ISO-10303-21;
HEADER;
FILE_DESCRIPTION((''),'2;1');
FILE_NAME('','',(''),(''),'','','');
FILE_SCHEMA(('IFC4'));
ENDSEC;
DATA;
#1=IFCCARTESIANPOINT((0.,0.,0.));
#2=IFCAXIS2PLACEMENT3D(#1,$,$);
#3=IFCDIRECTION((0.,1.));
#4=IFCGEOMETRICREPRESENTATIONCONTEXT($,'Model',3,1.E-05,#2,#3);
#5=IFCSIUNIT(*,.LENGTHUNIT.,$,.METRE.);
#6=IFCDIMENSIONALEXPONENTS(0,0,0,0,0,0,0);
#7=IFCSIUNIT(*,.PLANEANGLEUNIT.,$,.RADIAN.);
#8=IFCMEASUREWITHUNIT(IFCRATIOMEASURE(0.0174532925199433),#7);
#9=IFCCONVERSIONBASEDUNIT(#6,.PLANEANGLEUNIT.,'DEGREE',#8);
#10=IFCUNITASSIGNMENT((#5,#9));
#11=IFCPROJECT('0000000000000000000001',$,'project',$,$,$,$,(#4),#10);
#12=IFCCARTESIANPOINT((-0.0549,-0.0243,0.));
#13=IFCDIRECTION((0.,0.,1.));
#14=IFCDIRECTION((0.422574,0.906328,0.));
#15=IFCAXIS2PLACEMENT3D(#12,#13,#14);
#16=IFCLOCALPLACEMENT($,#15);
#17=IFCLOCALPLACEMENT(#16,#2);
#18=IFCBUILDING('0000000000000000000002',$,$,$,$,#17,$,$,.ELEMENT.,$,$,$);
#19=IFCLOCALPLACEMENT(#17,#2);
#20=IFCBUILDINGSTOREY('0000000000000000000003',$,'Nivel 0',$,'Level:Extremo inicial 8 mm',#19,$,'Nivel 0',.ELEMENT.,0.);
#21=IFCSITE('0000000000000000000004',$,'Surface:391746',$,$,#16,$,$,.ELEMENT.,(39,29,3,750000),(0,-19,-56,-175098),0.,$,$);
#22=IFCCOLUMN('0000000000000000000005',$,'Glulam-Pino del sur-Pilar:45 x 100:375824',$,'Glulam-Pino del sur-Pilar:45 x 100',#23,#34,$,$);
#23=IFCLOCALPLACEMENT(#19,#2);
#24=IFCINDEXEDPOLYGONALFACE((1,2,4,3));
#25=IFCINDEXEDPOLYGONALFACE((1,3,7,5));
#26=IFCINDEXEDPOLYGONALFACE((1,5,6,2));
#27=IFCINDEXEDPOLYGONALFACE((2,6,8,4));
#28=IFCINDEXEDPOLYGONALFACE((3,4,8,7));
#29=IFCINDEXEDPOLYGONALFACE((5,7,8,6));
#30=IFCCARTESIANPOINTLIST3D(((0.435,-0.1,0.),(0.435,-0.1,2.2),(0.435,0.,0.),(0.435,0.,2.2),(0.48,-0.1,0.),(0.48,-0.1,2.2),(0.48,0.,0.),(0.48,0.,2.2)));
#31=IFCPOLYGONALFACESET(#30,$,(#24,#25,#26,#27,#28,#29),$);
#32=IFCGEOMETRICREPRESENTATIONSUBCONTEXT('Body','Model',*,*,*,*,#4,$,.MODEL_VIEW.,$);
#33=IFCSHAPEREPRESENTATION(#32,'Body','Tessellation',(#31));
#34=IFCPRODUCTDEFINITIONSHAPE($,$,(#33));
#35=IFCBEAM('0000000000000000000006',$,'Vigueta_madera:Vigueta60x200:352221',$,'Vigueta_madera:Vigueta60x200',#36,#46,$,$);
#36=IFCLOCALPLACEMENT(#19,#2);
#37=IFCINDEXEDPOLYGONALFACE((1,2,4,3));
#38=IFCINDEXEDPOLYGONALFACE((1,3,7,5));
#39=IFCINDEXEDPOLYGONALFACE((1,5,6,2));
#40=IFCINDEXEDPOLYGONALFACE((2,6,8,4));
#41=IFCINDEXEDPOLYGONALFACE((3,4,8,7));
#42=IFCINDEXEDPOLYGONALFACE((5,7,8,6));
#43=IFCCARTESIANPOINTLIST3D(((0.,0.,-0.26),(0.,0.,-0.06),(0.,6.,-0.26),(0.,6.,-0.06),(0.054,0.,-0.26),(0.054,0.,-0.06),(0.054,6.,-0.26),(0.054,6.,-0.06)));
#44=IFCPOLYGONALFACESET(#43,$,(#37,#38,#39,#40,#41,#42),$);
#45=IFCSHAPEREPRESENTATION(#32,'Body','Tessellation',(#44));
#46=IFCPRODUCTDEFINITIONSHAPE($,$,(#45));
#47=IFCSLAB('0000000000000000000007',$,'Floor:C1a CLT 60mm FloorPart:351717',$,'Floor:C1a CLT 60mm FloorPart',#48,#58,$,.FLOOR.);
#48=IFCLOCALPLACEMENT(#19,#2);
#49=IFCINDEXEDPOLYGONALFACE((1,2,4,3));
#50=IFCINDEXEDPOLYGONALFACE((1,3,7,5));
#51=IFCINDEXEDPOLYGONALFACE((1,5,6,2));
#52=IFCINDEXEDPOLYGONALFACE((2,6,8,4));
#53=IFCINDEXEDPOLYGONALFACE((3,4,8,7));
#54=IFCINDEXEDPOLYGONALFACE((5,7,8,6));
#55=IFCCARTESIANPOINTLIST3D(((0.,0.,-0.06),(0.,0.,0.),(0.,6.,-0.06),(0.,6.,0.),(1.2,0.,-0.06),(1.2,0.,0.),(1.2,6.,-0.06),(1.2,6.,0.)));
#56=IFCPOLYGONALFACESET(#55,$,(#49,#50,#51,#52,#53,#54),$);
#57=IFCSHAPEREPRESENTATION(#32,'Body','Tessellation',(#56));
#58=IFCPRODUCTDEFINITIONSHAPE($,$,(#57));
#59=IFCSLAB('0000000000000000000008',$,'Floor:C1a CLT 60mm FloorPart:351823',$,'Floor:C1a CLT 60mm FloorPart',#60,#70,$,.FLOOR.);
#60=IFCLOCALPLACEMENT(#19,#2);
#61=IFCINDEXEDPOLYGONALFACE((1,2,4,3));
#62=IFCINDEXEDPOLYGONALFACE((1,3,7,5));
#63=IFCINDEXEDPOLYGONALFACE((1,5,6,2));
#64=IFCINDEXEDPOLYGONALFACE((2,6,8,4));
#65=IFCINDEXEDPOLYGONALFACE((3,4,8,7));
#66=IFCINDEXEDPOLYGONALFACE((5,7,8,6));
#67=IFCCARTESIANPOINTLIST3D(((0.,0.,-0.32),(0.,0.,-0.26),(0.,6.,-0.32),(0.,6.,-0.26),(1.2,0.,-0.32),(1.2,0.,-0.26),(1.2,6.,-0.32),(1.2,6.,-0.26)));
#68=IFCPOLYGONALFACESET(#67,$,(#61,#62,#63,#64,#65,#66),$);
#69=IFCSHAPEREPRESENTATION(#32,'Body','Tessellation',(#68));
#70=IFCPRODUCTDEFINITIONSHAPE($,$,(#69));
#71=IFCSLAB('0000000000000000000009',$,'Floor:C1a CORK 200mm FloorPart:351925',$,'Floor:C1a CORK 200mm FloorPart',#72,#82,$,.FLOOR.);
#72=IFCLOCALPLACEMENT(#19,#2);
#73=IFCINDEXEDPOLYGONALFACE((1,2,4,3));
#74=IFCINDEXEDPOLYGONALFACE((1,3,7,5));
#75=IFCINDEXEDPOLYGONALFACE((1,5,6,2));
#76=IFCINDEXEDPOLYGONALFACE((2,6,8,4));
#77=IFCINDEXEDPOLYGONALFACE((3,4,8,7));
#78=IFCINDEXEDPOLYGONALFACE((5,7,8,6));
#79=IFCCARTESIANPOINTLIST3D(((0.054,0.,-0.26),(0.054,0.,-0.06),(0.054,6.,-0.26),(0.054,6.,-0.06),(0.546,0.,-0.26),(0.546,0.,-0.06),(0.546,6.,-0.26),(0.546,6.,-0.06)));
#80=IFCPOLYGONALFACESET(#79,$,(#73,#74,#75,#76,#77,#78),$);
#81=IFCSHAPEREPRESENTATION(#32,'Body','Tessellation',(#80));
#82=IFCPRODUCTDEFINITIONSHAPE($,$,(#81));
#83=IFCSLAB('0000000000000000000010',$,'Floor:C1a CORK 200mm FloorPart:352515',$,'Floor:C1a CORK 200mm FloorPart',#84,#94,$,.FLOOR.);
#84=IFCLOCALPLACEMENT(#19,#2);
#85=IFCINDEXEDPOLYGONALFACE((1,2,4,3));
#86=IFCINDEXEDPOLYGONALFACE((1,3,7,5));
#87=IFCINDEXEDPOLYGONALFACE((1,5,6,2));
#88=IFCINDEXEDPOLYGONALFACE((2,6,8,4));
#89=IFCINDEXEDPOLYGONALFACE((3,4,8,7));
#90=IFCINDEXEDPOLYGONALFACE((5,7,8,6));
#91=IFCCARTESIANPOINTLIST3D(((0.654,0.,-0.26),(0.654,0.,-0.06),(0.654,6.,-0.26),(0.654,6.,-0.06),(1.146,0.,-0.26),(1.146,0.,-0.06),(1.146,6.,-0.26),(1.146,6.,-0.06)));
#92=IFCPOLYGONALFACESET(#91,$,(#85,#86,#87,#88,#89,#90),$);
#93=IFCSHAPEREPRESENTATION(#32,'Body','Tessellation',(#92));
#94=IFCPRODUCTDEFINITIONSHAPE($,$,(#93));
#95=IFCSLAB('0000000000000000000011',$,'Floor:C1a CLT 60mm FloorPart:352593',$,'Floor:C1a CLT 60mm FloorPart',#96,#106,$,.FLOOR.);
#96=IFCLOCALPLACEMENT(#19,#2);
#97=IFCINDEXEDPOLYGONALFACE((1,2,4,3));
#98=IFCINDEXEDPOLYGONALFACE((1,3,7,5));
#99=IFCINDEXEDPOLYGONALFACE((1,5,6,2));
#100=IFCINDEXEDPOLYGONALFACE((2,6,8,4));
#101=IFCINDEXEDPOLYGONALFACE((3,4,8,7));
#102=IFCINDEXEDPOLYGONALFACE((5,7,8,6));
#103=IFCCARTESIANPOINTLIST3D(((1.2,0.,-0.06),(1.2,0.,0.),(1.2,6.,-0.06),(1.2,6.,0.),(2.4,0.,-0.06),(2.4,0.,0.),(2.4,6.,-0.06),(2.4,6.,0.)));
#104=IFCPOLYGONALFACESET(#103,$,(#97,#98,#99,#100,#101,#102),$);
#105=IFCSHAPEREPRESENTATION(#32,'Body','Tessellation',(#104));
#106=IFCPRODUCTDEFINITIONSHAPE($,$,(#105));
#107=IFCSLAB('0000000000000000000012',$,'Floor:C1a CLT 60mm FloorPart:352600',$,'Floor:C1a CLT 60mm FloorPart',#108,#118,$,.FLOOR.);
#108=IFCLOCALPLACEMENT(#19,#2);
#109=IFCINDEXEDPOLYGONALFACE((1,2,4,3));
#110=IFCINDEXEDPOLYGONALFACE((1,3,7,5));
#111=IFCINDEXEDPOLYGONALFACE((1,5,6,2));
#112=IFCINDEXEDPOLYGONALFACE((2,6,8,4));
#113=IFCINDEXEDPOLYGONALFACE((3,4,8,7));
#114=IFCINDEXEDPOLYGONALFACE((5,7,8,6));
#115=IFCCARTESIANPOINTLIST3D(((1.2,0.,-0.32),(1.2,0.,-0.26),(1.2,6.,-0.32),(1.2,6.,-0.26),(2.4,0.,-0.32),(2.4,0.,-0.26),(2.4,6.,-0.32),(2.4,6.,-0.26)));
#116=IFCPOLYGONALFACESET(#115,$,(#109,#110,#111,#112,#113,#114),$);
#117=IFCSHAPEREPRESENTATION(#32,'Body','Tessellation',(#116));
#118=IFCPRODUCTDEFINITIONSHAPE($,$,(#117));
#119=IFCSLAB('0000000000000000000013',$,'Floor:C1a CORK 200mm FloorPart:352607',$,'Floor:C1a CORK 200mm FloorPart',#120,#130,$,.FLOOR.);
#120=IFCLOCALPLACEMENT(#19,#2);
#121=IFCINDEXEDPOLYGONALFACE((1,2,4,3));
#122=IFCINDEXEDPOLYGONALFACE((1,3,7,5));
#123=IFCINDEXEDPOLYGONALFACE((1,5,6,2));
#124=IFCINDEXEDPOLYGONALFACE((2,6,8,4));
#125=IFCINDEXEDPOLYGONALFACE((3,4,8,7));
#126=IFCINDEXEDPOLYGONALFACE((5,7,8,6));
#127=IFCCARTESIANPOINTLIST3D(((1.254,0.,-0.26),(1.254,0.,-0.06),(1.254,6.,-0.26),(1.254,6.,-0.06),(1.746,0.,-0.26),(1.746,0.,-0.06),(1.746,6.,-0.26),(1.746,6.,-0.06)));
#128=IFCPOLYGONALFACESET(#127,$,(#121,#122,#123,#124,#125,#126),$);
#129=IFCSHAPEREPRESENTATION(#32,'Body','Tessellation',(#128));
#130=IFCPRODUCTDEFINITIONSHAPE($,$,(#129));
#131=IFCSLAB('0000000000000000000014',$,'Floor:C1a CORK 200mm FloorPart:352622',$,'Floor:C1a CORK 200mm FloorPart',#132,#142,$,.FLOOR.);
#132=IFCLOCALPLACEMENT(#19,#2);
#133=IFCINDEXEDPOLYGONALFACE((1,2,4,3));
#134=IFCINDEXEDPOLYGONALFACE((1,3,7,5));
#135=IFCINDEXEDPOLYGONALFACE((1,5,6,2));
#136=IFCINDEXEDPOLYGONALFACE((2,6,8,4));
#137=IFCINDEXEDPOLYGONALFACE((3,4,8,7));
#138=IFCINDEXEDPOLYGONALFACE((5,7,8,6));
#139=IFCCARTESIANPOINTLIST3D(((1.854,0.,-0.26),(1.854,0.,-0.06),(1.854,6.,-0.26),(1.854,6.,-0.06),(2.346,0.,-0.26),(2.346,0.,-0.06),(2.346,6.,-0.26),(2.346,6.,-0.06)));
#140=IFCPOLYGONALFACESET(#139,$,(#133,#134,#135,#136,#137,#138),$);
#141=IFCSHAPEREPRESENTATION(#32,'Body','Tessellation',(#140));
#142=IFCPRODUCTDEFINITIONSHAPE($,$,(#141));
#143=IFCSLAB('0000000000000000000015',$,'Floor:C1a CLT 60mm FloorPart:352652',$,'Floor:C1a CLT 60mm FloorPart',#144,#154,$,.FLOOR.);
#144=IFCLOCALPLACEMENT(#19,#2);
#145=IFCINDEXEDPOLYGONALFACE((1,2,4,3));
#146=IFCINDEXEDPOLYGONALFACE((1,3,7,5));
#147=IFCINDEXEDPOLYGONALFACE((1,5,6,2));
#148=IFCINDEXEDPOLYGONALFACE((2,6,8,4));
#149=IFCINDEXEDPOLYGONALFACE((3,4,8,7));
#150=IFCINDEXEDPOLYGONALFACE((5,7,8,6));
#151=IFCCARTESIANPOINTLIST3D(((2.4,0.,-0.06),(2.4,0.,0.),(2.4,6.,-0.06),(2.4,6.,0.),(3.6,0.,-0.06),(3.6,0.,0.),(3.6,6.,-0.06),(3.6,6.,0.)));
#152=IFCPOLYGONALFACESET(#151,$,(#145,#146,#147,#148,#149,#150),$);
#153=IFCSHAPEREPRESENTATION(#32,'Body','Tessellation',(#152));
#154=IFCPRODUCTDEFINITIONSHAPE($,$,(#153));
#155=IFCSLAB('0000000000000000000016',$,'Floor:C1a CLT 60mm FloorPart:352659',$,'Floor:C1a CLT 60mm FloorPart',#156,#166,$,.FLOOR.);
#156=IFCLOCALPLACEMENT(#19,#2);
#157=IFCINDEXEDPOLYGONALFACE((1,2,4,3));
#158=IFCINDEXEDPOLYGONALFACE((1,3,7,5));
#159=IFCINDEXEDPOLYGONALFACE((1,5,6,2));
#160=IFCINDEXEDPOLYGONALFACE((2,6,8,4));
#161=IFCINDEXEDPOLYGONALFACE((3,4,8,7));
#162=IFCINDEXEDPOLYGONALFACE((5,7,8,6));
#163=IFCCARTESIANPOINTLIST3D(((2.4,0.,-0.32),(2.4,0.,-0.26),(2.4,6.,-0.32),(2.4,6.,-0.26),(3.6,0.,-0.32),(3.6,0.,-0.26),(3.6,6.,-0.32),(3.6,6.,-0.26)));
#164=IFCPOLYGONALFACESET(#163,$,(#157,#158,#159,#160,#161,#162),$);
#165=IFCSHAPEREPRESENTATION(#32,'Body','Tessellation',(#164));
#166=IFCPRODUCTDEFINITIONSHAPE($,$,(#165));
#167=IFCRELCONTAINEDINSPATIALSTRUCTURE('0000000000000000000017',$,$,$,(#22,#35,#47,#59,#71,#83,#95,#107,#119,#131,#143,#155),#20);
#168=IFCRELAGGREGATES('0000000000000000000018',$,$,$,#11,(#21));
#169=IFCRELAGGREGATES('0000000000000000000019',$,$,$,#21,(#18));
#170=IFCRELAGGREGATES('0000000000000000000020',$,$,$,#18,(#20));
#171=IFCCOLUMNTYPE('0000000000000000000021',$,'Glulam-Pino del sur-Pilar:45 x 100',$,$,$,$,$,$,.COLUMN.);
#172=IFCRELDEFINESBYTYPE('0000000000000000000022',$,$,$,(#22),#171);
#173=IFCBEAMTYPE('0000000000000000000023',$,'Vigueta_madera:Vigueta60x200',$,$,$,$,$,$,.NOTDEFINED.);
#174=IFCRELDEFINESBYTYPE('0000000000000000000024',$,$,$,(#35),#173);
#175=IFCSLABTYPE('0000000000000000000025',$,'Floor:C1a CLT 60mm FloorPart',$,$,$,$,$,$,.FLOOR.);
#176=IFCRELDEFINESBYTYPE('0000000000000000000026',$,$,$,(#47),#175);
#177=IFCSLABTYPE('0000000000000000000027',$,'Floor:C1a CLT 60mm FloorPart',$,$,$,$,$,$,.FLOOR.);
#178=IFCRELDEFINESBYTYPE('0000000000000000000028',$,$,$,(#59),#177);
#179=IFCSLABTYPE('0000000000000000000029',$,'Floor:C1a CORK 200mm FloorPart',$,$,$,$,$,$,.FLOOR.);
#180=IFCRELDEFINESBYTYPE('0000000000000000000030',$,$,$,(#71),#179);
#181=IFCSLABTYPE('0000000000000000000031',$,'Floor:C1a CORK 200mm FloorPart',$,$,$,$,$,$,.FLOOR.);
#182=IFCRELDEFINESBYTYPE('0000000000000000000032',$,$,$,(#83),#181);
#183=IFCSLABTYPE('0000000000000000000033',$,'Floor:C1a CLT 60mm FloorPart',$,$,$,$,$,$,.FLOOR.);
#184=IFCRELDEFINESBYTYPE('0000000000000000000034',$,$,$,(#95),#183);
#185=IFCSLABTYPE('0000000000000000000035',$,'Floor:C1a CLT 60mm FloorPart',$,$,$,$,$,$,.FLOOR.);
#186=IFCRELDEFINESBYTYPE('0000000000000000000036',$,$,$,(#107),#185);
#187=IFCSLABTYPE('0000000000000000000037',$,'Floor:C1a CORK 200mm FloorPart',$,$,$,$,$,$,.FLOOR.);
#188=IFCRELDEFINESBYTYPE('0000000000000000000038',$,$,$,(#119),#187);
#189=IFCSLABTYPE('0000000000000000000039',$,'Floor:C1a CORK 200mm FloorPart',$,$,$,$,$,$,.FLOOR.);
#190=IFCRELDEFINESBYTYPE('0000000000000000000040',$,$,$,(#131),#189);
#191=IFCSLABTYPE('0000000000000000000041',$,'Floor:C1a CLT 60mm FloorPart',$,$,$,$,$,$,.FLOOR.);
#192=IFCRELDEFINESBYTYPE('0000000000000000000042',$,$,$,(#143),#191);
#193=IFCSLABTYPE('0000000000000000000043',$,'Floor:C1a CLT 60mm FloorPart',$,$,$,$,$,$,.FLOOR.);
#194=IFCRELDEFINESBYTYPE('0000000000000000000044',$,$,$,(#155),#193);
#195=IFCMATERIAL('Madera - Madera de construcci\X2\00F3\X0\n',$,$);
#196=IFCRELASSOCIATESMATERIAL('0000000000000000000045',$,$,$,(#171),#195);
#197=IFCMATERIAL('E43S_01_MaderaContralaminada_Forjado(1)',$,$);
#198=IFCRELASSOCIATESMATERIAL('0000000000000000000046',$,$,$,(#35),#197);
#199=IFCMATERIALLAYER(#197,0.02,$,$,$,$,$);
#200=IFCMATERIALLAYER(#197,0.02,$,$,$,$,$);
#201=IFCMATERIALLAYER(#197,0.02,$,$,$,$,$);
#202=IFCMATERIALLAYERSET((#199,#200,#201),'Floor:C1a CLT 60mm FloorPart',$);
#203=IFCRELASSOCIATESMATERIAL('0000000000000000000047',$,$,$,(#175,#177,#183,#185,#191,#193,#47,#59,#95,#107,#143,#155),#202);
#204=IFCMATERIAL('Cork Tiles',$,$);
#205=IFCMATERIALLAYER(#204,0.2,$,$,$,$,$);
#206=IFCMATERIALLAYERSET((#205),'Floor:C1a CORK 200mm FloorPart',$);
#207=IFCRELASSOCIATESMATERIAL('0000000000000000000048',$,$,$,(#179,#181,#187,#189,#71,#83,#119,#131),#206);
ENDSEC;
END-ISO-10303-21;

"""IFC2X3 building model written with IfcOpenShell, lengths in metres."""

from ifc_helpers import new_model, entity, si_unit, converted_unit, direction, frame, frame_2d, origin, origin_2d_with_axis, place, context, subcontext, project, spatial, rectangle, extrude, source, transform, mapped, material, layer, layer_set, layer_usage, type_object, type_shapes, element, save


model = new_model("IFC2X3")

# Units and contexts
model_context = context("Model", 3, precision=1e-05, world=origin(), true_north=direction((0.0, 1.0)))
body_context = subcontext(model_context, "Body", "Model", "MODEL_VIEW")
ifc_project = project(units=[si_unit("LENGTHUNIT", "METRE"), converted_unit("PLANEANGLEUNIT", "DEGREE", entity("IfcRatioMeasure", 0.0174532925199433), si_unit("PLANEANGLEUNIT", "RADIAN"), dimensions=[0, 0, 0, 0, 0, 0, 0])], contexts=[model_context])

# Site, building, storey
site_placement = place(None, frame((-0.0549, -0.0243, 0.0), z_axis=(0.0, 0.0, 1.0), x_axis=(0.422574, 0.906328, 0.0)))
site = spatial("IfcSite", under=ifc_project, at=site_placement, Name="Surface:391746", CompositionType="ELEMENT", RefLatitude=(39, 29, 3, 750000), RefLongitude=(0, -19, -56, -175098), RefElevation=0.0)
building_placement = place(site_placement, origin())
building = spatial("IfcBuilding", under=site, at=building_placement, CompositionType="ELEMENT")
storey_placement = place(building_placement, origin())
storey = spatial("IfcBuildingStorey", under=building, at=storey_placement, Name="Nivel 0", ObjectType="Level:Extremo inicial 8 mm", LongName="Nivel 0", CompositionType="ELEMENT", Elevation=0.0)

# Column
ifc_material_1 = material(Name="Madera - Madera de construcción")
column_type = type_object("IfcColumnType", Name="Glulam-Pino del sur-Pilar:45 x 100", PredefinedType="COLUMN", material=ifc_material_1)
shared_shape_1 = source(origin(), body_context, "Body", "SweptSolid", [
    extrude(rectangle(XDim=0.1, YDim=0.045, at=origin_2d_with_axis()), frame((0.0, 0.0, 0.0), z_axis=(0.0, 0.0, 1.0), x_axis=(0.0, -1.0, 0.0)), (0.0, 0.0, 1.0), 2.2),
])
type_shapes(column_type, [shared_shape_1])
column_placement = place(storey_placement, frame((0.4575, -0.05, 0.0), z_axis=(0.0, 0.0, 1.0), x_axis=(-1.0, 0.0, 0.0)))
element("IfcColumn", 1, at=column_placement, inside=storey, type_object=column_type, Name="Glulam-Pino del sur-Pilar:45 x 100:375824", ObjectType="Glulam-Pino del sur-Pilar:45 x 100", context=body_context, shape_type="MappedRepresentation", body=[
    mapped(shared_shape_1, transform((0.0, 0.0, 0.0), scale=1.0)),
])

# Beam
ifc_material_2 = material(Name="E43S_01_MaderaContralaminada_Forjado(1)")
beam_type = type_object("IfcBeamType", Name="Vigueta_madera:Vigueta60x200", PredefinedType="NOTDEFINED")
beam_placement = place(storey_placement, frame((0.027, 0.0, -0.06), z_axis=(0.0, 0.0, 1.0), x_axis=(0.0, 1.0, 0.0)))
element("IfcBeam", 2, at=beam_placement, inside=storey, type_object=beam_type, material=ifc_material_2, Name="Vigueta_madera:Vigueta60x200:352221", ObjectType="Vigueta_madera:Vigueta60x200", context=body_context, shape_type="SweptSolid", body=[
    extrude(rectangle(XDim=0.2, YDim=0.054, at=origin_2d_with_axis()), frame((0.0, 0.0, -0.1), z_axis=(1.0, 0.0, 0.0), x_axis=(0.0, 0.0, -1.0)), (0.0, 0.0, 1.0), 6.0),
])

# Slabs
ifc_layer_1 = layer(ifc_material_2, 0.02)
ifc_layer_2 = layer(ifc_material_2, 0.02)
ifc_layer_3 = layer(ifc_material_2, 0.02)
ifc_layer_set_1 = layer_set([ifc_layer_1, ifc_layer_2, ifc_layer_3], Name="Floor:C1a CLT 60mm FloorPart")
ifc_layer_usage_1 = layer_usage(ifc_layer_set_1, "AXIS3", "POSITIVE", 0.0)
slab_type_1 = type_object("IfcSlabType", Name="Floor:C1a CLT 60mm FloorPart", PredefinedType="FLOOR", material=ifc_layer_set_1)
slab_1_placement = place(storey_placement, origin())
element("IfcSlab", 3, at=slab_1_placement, inside=storey, type_object=slab_type_1, material=ifc_layer_usage_1, Name="Floor:C1a CLT 60mm FloorPart:351717", ObjectType="Floor:C1a CLT 60mm FloorPart", PredefinedType="FLOOR", context=body_context, shape_type="SweptSolid", body=[
    extrude(rectangle(XDim=6.0, YDim=1.2, at=frame_2d((0.0, 0.0), x_axis=(1.0, 0.0))), frame((0.6, 3.0, 0.0), z_axis=(0.0, 0.0, -1.0), x_axis=(0.0, 1.0, 0.0)), (0.0, 0.0, 1.0), 0.06),
])
ifc_layer_usage_2 = layer_usage(ifc_layer_set_1, "AXIS3", "POSITIVE", 0.0)
slab_type_2 = type_object("IfcSlabType", Name="Floor:C1a CLT 60mm FloorPart", PredefinedType="FLOOR", material=ifc_layer_set_1)
slab_2_placement = place(storey_placement, origin())
element("IfcSlab", 4, at=slab_2_placement, inside=storey, type_object=slab_type_2, material=ifc_layer_usage_2, Name="Floor:C1a CLT 60mm FloorPart:351823", ObjectType="Floor:C1a CLT 60mm FloorPart", PredefinedType="FLOOR", context=body_context, shape_type="SweptSolid", body=[
    extrude(rectangle(XDim=6.0, YDim=1.2, at=frame_2d((0.0, 0.0), x_axis=(1.0, 0.0))), frame((0.6, 3.0, -0.26), z_axis=(0.0, 0.0, -1.0), x_axis=(0.0, 1.0, 0.0)), (0.0, 0.0, 1.0), 0.06),
])
ifc_material_3 = material(Name="Cork Tiles")
ifc_layer_4 = layer(ifc_material_3, 0.2)
ifc_layer_set_2 = layer_set([ifc_layer_4], Name="Floor:C1a CORK 200mm FloorPart")
ifc_layer_usage_3 = layer_usage(ifc_layer_set_2, "AXIS3", "POSITIVE", 0.0)
slab_type_3 = type_object("IfcSlabType", Name="Floor:C1a CORK 200mm FloorPart", PredefinedType="FLOOR", material=ifc_layer_set_2)
slab_3_placement = place(storey_placement, origin())
element("IfcSlab", 5, at=slab_3_placement, inside=storey, type_object=slab_type_3, material=ifc_layer_usage_3, Name="Floor:C1a CORK 200mm FloorPart:351925", ObjectType="Floor:C1a CORK 200mm FloorPart", PredefinedType="FLOOR", context=body_context, shape_type="SweptSolid", body=[
    extrude(rectangle(XDim=6.0, YDim=0.492, at=frame_2d((0.0, 0.0), x_axis=(1.0, 0.0))), frame((0.3, 3.0, -0.06), z_axis=(0.0, 0.0, -1.0), x_axis=(0.0, 1.0, 0.0)), (0.0, 0.0, 1.0), 0.2),
])
ifc_layer_usage_4 = layer_usage(ifc_layer_set_2, "AXIS3", "POSITIVE", 0.0)
slab_type_4 = type_object("IfcSlabType", Name="Floor:C1a CORK 200mm FloorPart", PredefinedType="FLOOR", material=ifc_layer_set_2)
slab_4_placement = place(storey_placement, origin())
element("IfcSlab", 6, at=slab_4_placement, inside=storey, type_object=slab_type_4, material=ifc_layer_usage_4, Name="Floor:C1a CORK 200mm FloorPart:352515", ObjectType="Floor:C1a CORK 200mm FloorPart", PredefinedType="FLOOR", context=body_context, shape_type="SweptSolid", body=[
    extrude(rectangle(XDim=6.0, YDim=0.492, at=frame_2d((0.0, 0.0), x_axis=(1.0, 0.0))), frame((0.9, 3.0, -0.06), z_axis=(0.0, 0.0, -1.0), x_axis=(0.0, 1.0, 0.0)), (0.0, 0.0, 1.0), 0.2),
])
ifc_layer_usage_5 = layer_usage(ifc_layer_set_1, "AXIS3", "POSITIVE", 0.0)
slab_type_5 = type_object("IfcSlabType", Name="Floor:C1a CLT 60mm FloorPart", PredefinedType="FLOOR", material=ifc_layer_set_1)
slab_5_placement = place(storey_placement, origin())
element("IfcSlab", 7, at=slab_5_placement, inside=storey, type_object=slab_type_5, material=ifc_layer_usage_5, Name="Floor:C1a CLT 60mm FloorPart:352593", ObjectType="Floor:C1a CLT 60mm FloorPart", PredefinedType="FLOOR", context=body_context, shape_type="SweptSolid", body=[
    extrude(rectangle(XDim=6.0, YDim=1.2, at=frame_2d((0.0, 0.0), x_axis=(1.0, 0.0))), frame((1.8, 3.0, 0.0), z_axis=(0.0, 0.0, -1.0), x_axis=(0.0, 1.0, 0.0)), (0.0, 0.0, 1.0), 0.06),
])
ifc_layer_usage_6 = layer_usage(ifc_layer_set_1, "AXIS3", "POSITIVE", 0.0)
slab_type_6 = type_object("IfcSlabType", Name="Floor:C1a CLT 60mm FloorPart", PredefinedType="FLOOR", material=ifc_layer_set_1)
slab_6_placement = place(storey_placement, origin())
element("IfcSlab", 8, at=slab_6_placement, inside=storey, type_object=slab_type_6, material=ifc_layer_usage_6, Name="Floor:C1a CLT 60mm FloorPart:352600", ObjectType="Floor:C1a CLT 60mm FloorPart", PredefinedType="FLOOR", context=body_context, shape_type="SweptSolid", body=[
    extrude(rectangle(XDim=6.0, YDim=1.2, at=frame_2d((0.0, 0.0), x_axis=(1.0, 0.0))), frame((1.8, 3.0, -0.26), z_axis=(0.0, 0.0, -1.0), x_axis=(0.0, 1.0, 0.0)), (0.0, 0.0, 1.0), 0.06),
])
ifc_layer_usage_7 = layer_usage(ifc_layer_set_2, "AXIS3", "POSITIVE", 0.0)
slab_type_7 = type_object("IfcSlabType", Name="Floor:C1a CORK 200mm FloorPart", PredefinedType="FLOOR", material=ifc_layer_set_2)
slab_7_placement = place(storey_placement, origin())
element("IfcSlab", 9, at=slab_7_placement, inside=storey, type_object=slab_type_7, material=ifc_layer_usage_7, Name="Floor:C1a CORK 200mm FloorPart:352607", ObjectType="Floor:C1a CORK 200mm FloorPart", PredefinedType="FLOOR", context=body_context, shape_type="SweptSolid", body=[
    extrude(rectangle(XDim=6.0, YDim=0.492, at=frame_2d((0.0, 0.0), x_axis=(1.0, 0.0))), frame((1.5, 3.0, -0.06), z_axis=(0.0, 0.0, -1.0), x_axis=(0.0, 1.0, 0.0)), (0.0, 0.0, 1.0), 0.2),
])
ifc_layer_usage_8 = layer_usage(ifc_layer_set_2, "AXIS3", "POSITIVE", 0.0)
slab_type_8 = type_object("IfcSlabType", Name="Floor:C1a CORK 200mm FloorPart", PredefinedType="FLOOR", material=ifc_layer_set_2)
slab_8_placement = place(storey_placement, origin())
element("IfcSlab", 10, at=slab_8_placement, inside=storey, type_object=slab_type_8, material=ifc_layer_usage_8, Name="Floor:C1a CORK 200mm FloorPart:352622", ObjectType="Floor:C1a CORK 200mm FloorPart", PredefinedType="FLOOR", context=body_context, shape_type="SweptSolid", body=[
    extrude(rectangle(XDim=6.0, YDim=0.492, at=frame_2d((0.0, 0.0), x_axis=(1.0, 0.0))), frame((2.1, 3.0, -0.06), z_axis=(0.0, 0.0, -1.0), x_axis=(0.0, 1.0, 0.0)), (0.0, 0.0, 1.0), 0.2),
])
ifc_layer_usage_9 = layer_usage(ifc_layer_set_1, "AXIS3", "POSITIVE", 0.0)
slab_type_9 = type_object("IfcSlabType", Name="Floor:C1a CLT 60mm FloorPart", PredefinedType="FLOOR", material=ifc_layer_set_1)
slab_9_placement = place(storey_placement, origin())
element("IfcSlab", 11, at=slab_9_placement, inside=storey, type_object=slab_type_9, material=ifc_layer_usage_9, Name="Floor:C1a CLT 60mm FloorPart:352652", ObjectType="Floor:C1a CLT 60mm FloorPart", PredefinedType="FLOOR", context=body_context, shape_type="SweptSolid", body=[
    extrude(rectangle(XDim=6.0, YDim=1.2, at=frame_2d((0.0, 0.0), x_axis=(1.0, 0.0))), frame((3.0, 3.0, 0.0), z_axis=(0.0, 0.0, -1.0), x_axis=(0.0, 1.0, 0.0)), (0.0, 0.0, 1.0), 0.06),
])
ifc_layer_usage_10 = layer_usage(ifc_layer_set_1, "AXIS3", "POSITIVE", 0.0)
slab_type_10 = type_object("IfcSlabType", Name="Floor:C1a CLT 60mm FloorPart", PredefinedType="FLOOR", material=ifc_layer_set_1)
slab_10_placement = place(storey_placement, origin())
element("IfcSlab", 12, at=slab_10_placement, inside=storey, type_object=slab_type_10, material=ifc_layer_usage_10, Name="Floor:C1a CLT 60mm FloorPart:352659", ObjectType="Floor:C1a CLT 60mm FloorPart", PredefinedType="FLOOR", context=body_context, shape_type="SweptSolid", body=[
    extrude(rectangle(XDim=6.0, YDim=1.2, at=frame_2d((0.0, 0.0), x_axis=(1.0, 0.0))), frame((3.0, 3.0, -0.26), z_axis=(0.0, 0.0, -1.0), x_axis=(0.0, 1.0, 0.0)), (0.0, 0.0, 1.0), 0.06),
])

save(model, "model.ifc")
